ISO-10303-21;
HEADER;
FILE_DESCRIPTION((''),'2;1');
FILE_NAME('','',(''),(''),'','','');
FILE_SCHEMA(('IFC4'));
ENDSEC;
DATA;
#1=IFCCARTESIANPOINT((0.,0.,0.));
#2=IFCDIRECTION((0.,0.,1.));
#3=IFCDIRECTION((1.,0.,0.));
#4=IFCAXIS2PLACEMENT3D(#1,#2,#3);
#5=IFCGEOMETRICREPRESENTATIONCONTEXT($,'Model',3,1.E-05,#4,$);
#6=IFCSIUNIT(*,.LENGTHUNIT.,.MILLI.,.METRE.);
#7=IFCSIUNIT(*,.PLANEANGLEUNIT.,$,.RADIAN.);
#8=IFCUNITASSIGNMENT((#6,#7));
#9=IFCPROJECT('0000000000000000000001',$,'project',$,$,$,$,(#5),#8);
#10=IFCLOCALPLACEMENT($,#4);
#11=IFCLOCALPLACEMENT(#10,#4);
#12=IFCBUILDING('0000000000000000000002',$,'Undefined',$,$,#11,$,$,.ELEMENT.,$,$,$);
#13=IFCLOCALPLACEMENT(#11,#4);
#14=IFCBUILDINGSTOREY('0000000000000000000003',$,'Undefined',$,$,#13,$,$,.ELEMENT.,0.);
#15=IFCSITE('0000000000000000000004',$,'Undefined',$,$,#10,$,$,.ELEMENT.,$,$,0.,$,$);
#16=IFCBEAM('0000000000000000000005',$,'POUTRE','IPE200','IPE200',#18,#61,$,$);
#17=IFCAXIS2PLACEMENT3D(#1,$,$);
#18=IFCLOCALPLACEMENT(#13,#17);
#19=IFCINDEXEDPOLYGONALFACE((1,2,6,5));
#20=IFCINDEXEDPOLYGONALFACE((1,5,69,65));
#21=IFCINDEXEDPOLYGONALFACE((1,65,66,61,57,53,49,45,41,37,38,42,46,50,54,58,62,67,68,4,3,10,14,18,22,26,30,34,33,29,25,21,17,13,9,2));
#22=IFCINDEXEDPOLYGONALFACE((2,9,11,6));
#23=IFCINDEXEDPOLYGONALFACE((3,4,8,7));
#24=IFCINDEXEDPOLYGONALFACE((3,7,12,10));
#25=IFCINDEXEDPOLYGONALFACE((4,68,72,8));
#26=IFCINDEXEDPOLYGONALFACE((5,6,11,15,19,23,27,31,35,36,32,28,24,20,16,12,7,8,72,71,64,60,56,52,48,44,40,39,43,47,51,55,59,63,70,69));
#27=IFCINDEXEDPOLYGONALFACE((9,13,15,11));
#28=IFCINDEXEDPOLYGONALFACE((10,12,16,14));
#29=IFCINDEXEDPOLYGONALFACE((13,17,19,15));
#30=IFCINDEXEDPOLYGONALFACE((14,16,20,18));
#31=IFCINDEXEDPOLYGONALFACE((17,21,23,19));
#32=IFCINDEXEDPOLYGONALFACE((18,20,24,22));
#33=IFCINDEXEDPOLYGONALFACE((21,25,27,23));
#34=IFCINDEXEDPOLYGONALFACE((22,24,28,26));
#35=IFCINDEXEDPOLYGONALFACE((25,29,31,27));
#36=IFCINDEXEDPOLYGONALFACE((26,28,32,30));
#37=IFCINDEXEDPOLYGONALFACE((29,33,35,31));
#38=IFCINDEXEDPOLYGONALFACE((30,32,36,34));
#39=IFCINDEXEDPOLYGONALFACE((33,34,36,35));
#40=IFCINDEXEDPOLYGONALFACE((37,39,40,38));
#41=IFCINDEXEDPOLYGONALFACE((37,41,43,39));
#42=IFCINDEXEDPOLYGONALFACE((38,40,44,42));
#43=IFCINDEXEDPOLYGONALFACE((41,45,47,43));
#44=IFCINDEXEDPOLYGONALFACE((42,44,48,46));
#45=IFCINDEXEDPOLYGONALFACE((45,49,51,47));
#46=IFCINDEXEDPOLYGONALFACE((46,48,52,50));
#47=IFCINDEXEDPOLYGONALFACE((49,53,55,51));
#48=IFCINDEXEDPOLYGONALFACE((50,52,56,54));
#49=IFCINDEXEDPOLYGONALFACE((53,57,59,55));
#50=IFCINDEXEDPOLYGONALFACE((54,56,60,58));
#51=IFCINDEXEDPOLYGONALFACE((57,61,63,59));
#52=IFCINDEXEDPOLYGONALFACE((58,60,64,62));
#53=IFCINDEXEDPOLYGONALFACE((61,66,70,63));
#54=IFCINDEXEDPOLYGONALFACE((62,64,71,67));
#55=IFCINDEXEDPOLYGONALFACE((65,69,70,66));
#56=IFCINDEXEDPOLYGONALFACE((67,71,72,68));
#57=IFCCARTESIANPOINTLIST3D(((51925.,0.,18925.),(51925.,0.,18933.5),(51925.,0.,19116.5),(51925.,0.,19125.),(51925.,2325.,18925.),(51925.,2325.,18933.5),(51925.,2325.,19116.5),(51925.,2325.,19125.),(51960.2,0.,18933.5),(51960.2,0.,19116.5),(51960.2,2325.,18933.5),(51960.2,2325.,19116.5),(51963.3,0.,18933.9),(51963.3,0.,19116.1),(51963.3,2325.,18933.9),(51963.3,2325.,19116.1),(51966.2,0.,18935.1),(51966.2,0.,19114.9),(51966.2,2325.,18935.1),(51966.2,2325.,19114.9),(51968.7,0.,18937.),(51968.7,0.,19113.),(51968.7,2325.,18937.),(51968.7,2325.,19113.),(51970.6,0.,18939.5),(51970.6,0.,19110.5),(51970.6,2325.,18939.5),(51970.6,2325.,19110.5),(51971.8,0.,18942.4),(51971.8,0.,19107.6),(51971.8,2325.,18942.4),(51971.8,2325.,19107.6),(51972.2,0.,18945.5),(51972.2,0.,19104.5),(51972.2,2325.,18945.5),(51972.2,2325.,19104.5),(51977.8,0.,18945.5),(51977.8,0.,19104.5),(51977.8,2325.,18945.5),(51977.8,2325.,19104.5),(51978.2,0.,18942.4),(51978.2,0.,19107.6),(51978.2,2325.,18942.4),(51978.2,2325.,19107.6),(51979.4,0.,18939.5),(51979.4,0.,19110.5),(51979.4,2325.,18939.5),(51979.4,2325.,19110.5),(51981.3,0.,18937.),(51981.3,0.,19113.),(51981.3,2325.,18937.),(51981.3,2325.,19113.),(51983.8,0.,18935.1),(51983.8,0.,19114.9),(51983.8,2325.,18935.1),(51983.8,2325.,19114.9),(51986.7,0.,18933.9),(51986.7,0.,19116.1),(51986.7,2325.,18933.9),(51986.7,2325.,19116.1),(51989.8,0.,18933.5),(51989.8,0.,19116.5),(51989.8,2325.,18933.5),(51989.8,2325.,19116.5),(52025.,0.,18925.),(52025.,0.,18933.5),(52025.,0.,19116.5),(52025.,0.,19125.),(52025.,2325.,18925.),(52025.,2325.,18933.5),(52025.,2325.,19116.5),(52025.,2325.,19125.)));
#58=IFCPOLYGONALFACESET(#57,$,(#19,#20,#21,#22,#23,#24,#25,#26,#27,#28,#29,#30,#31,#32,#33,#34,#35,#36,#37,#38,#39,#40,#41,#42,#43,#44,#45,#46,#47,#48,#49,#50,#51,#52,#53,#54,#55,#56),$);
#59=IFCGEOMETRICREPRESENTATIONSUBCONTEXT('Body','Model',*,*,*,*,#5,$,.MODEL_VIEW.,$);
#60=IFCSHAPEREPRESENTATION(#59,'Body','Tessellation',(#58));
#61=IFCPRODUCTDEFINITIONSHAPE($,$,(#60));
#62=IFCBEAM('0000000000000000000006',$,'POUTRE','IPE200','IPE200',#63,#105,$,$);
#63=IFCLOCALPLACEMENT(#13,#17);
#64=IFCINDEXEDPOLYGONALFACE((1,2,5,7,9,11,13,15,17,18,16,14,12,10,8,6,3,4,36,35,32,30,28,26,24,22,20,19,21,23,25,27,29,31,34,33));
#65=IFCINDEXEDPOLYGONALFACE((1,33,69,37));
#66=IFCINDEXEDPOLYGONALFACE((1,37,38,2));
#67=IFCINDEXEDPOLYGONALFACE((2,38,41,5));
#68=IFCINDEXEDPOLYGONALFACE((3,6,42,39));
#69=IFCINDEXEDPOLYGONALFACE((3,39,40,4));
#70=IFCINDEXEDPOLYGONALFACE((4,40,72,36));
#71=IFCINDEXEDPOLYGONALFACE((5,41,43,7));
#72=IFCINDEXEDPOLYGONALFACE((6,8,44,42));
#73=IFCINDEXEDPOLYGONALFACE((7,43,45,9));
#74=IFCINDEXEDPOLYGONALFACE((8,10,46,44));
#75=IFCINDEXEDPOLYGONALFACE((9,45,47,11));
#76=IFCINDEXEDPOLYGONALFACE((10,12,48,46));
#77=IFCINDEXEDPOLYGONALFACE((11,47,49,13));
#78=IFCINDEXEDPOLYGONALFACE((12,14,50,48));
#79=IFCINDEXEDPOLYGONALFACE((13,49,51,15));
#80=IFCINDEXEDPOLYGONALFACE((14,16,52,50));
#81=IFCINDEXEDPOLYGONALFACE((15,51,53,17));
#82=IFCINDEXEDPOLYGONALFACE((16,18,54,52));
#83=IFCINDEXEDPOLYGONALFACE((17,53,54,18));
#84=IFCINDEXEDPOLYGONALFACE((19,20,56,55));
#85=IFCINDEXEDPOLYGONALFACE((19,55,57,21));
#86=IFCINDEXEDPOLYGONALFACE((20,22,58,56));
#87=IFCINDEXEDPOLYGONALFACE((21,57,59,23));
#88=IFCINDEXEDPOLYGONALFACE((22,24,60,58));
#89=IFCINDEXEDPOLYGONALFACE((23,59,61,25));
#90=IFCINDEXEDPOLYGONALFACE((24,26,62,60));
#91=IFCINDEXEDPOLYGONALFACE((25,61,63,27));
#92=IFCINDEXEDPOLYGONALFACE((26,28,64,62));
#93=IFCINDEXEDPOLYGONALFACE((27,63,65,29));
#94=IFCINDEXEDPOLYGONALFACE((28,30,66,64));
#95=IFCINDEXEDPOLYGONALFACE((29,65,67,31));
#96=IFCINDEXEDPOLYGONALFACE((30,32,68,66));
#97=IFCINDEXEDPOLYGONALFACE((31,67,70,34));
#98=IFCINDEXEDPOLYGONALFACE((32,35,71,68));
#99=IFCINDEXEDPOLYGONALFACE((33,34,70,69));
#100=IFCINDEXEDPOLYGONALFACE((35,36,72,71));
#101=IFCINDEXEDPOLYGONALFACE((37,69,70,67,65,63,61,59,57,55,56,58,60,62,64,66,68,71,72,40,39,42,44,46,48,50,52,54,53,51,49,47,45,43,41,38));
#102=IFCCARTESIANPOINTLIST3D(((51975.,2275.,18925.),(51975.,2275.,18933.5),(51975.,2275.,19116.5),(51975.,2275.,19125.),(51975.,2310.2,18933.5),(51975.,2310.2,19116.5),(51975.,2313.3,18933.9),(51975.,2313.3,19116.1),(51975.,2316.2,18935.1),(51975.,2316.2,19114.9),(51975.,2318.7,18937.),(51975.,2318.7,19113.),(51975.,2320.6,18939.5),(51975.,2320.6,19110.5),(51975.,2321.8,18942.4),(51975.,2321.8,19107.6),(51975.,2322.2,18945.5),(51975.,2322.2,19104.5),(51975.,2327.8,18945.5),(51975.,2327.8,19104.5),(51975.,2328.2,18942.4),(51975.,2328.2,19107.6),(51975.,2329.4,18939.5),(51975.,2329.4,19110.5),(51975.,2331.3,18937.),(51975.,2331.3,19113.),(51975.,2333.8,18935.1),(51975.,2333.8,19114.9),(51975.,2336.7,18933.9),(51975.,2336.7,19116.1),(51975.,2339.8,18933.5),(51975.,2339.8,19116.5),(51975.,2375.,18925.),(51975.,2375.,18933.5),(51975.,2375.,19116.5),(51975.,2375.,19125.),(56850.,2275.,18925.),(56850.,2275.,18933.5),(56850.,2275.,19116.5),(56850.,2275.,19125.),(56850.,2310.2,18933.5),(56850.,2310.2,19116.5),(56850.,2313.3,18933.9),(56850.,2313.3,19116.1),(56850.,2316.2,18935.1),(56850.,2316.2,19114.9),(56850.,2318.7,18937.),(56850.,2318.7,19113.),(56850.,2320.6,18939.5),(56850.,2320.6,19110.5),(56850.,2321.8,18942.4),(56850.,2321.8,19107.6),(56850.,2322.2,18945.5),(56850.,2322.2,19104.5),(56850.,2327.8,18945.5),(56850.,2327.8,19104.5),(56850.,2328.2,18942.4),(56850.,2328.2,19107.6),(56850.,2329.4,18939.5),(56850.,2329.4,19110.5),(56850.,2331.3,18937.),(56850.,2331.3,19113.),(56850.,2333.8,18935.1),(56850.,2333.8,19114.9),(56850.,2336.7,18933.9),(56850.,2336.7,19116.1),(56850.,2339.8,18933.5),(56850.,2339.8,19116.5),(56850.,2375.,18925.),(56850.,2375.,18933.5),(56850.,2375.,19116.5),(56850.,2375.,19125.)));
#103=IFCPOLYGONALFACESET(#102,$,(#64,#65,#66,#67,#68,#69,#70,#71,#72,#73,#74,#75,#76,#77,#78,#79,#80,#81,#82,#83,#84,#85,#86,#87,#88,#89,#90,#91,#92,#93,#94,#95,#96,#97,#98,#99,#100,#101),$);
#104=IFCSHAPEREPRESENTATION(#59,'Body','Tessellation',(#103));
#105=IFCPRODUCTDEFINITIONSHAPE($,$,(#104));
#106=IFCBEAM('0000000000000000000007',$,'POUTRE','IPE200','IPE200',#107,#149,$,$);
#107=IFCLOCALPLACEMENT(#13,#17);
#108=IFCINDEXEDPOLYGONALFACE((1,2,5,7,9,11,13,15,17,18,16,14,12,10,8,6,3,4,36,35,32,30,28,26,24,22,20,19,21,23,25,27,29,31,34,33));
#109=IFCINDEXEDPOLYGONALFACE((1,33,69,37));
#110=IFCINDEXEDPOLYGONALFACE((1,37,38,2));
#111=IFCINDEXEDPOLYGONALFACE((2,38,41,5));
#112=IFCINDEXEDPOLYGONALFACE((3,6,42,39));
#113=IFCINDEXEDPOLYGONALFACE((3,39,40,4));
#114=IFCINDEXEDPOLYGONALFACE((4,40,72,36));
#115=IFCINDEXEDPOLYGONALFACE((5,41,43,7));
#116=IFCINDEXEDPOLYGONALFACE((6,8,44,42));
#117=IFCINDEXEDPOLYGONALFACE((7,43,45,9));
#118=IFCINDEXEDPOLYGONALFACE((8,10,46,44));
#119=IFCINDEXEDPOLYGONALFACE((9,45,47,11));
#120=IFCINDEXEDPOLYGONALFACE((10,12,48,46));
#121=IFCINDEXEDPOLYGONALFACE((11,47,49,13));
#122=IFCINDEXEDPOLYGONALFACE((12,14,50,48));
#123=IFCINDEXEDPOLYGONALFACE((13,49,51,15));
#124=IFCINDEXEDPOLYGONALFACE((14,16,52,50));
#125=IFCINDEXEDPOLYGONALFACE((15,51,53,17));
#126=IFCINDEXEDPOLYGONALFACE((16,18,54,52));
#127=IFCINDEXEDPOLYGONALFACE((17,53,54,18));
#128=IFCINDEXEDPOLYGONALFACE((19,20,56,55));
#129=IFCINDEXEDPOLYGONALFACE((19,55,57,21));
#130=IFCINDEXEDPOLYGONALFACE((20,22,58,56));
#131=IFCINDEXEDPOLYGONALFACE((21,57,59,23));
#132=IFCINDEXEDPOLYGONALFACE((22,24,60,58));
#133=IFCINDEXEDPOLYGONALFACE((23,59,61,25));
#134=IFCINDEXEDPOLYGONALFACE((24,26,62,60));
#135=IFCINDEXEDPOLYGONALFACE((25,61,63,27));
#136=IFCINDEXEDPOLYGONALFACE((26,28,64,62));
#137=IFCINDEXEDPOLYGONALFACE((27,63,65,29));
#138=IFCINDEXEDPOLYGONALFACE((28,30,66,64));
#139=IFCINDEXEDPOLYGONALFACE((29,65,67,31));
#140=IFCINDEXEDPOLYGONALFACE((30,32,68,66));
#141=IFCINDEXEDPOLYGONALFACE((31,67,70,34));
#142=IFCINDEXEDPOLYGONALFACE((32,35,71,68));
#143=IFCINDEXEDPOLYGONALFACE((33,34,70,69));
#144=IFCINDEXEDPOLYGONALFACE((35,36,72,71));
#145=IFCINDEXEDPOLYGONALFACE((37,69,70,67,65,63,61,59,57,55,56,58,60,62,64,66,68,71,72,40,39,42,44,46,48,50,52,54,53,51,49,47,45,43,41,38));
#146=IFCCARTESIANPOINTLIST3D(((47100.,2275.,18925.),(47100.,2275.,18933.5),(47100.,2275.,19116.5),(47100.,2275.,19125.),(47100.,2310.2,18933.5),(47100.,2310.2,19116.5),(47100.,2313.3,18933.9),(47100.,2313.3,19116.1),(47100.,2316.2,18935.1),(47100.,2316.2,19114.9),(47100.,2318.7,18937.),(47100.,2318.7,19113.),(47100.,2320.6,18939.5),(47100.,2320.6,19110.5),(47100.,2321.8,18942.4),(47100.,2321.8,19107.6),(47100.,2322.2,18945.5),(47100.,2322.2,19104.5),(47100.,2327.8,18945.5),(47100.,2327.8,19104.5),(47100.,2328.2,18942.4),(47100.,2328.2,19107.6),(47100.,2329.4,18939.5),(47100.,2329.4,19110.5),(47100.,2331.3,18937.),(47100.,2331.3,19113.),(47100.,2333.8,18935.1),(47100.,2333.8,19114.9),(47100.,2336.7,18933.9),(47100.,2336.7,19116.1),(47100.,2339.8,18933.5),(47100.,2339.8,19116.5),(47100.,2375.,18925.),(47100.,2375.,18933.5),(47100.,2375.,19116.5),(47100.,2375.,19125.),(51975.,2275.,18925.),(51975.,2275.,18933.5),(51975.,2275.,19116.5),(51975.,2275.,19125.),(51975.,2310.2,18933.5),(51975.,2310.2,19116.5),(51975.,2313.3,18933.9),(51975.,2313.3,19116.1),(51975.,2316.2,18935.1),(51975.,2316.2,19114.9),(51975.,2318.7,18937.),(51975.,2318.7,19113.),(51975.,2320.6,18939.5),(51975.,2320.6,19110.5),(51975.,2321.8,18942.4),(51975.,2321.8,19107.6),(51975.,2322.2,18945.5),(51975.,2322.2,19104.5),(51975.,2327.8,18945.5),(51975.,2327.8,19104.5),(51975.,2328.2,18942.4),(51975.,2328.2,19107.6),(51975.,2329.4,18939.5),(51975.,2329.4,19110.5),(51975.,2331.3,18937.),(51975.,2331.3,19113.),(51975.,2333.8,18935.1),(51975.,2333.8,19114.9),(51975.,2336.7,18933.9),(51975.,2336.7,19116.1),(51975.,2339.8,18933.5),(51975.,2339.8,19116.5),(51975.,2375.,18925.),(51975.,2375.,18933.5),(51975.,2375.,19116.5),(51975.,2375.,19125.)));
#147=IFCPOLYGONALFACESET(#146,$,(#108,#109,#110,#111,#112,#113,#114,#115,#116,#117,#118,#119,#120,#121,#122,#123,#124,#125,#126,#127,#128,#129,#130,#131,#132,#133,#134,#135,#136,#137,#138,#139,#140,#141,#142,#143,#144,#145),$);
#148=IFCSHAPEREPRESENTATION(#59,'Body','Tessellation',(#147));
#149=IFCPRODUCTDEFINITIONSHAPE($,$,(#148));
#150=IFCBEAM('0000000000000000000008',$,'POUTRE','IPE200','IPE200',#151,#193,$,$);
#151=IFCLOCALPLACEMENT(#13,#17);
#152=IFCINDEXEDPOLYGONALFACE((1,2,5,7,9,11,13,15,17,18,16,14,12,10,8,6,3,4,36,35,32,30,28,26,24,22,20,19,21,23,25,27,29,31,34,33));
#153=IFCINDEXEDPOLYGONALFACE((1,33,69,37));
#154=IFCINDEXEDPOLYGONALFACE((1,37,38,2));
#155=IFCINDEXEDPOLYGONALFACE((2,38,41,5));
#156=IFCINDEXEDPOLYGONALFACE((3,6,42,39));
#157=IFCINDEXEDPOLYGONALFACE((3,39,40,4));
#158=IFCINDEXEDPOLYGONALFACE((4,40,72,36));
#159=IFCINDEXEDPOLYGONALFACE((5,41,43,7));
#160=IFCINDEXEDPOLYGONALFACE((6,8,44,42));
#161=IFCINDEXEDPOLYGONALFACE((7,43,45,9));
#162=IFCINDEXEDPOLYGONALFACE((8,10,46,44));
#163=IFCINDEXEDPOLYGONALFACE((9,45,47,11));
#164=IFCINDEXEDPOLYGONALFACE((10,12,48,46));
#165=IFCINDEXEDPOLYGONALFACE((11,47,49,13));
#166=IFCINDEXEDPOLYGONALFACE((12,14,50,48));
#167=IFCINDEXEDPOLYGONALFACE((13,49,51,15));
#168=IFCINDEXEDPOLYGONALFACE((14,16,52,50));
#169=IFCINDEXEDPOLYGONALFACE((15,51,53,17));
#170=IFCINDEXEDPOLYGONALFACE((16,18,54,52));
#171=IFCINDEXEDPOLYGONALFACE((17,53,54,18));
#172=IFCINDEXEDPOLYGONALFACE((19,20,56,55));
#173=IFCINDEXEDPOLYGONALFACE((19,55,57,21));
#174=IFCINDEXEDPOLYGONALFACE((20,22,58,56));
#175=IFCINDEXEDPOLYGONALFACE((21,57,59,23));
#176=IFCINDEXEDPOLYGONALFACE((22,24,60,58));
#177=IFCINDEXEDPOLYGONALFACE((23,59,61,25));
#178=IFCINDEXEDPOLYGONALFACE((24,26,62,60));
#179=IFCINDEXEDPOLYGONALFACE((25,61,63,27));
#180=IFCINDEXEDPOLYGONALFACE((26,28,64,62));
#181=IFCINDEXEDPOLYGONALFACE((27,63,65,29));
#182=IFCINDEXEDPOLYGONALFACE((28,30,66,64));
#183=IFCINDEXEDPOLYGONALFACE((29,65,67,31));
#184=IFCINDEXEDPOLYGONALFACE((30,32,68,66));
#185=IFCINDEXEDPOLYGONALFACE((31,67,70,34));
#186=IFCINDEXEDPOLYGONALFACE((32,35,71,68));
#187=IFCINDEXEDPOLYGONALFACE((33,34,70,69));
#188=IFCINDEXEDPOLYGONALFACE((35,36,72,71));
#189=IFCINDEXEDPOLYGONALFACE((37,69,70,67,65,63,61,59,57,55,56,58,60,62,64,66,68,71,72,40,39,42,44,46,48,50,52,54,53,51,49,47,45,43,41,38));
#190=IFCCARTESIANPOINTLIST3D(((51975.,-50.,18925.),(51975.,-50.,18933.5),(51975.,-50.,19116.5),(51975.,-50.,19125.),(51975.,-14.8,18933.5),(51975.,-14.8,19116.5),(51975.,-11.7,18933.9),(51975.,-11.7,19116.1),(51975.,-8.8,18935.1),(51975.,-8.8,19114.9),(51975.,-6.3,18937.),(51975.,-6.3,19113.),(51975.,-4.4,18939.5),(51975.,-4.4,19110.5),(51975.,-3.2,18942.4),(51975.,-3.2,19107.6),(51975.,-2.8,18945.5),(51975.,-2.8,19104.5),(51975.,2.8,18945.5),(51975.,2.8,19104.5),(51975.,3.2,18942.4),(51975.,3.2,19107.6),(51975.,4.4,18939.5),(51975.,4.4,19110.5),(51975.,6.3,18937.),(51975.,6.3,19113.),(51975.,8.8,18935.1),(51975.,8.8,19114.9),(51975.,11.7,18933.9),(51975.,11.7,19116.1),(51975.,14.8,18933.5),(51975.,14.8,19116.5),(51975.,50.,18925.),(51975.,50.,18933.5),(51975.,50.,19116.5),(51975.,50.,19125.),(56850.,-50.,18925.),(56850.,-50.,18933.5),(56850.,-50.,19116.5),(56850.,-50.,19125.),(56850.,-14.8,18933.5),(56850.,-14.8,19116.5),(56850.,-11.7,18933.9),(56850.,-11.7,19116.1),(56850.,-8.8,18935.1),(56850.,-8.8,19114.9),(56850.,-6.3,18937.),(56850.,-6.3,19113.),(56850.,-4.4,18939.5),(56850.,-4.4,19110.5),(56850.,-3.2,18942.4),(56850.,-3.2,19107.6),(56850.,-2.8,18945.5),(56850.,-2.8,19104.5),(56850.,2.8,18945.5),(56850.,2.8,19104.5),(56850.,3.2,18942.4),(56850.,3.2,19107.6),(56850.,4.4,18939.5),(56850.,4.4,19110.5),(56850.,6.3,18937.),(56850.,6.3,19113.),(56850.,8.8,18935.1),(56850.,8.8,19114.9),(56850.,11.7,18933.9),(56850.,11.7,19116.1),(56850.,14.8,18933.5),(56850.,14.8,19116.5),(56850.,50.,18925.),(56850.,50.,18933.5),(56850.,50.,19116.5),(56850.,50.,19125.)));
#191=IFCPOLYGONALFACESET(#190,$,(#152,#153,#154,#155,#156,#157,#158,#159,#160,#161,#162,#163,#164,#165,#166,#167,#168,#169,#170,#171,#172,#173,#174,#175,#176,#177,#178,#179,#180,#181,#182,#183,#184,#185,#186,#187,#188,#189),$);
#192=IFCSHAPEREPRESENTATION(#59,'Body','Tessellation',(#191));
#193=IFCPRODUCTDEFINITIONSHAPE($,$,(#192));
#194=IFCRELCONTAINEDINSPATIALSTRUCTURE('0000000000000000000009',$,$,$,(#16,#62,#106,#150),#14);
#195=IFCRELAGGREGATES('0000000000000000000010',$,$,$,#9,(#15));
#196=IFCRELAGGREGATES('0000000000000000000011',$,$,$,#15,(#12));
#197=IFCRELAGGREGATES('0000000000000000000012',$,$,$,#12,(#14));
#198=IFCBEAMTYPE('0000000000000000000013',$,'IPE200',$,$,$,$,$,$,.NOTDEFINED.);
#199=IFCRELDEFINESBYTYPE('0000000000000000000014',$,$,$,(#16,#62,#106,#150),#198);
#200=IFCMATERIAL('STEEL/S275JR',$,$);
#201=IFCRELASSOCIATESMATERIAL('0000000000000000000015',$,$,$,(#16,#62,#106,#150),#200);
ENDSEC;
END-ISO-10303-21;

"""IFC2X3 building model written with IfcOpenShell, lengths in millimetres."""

from ifc_helpers import new_model, si_unit, frame, origin_with_axes, origin_2d_with_axis, place, context, subcontext, project, spatial, i_section, extrude, material, type_object, element, save


model = new_model("IFC2X3")

# Units and contexts
model_context = context("Model", 3, precision=1e-05, world=origin_with_axes())
body_context = subcontext(model_context, "Body", "Model", "MODEL_VIEW")
ifc_project = project(units=[si_unit("LENGTHUNIT", "METRE", prefix="MILLI"), si_unit("PLANEANGLEUNIT", "RADIAN")], contexts=[model_context])

# Site, building, storey
site_placement = place(None, origin_with_axes())
site = spatial("IfcSite", under=ifc_project, at=site_placement, Name="Undefined", CompositionType="ELEMENT", RefElevation=0.0)
building_placement = place(site_placement, origin_with_axes())
building = spatial("IfcBuilding", under=site, at=building_placement, Name="Undefined", CompositionType="ELEMENT")
storey_placement = place(building_placement, origin_with_axes())
storey = spatial("IfcBuildingStorey", under=building, at=storey_placement, Name="Undefined", CompositionType="ELEMENT", Elevation=0.0)

# Shared definitions
ifc_material_1 = material(Name="STEEL/S275JR")

# Beams
beam_type_1 = type_object("IfcBeamType", Name="IPE200", PredefinedType="NOTDEFINED")
beam_1_placement = place(storey_placement, frame((51975.0, 0.0, 19025.0), z_axis=(0.0, 0.000013, 1.0), x_axis=(0.0, 1.0, -0.000013)))
element("IfcBeam", 1, at=beam_1_placement, inside=storey, type_object=beam_type_1, material=ifc_material_1, Name="POUTRE", Description="IPE200", ObjectType="IPE200", context=body_context, shape_type="SweptSolid", body=[
    extrude(i_section(OverallWidth=100.0, OverallDepth=200.0, WebThickness=5.6, FlangeThickness=8.5, FilletRadius=12.0, at=origin_2d_with_axis()), frame((2325.0, 0.0, 0.0), z_axis=(-1.0, 0.0, 0.0), x_axis=(0.0, -1.0, 0.0)), (0.0, 0.0, 1.0), 2325.0),
])
for number, where, z_axis, x_axis, name in (
    (2, (51975.0, 2325.0, 19025.0), (0.0, 0.0, 1.0), (1.0, 0.0, 0.0), "POUTRE"),
    (3, (47100.0, 2325.0, 19025.0), (0.0, 0.0, 1.0), (1.0, 0.0, 0.0), "POUTRE"),
    (4, (51975.0, 0.0, 19025.0), (0.000006, 0.0, 1.0), (1.0, 0.0, -0.000006), "POUTRE"),
):
    element("IfcBeam", number, at=place(storey_placement, frame(where, z_axis=z_axis, x_axis=x_axis)), inside=storey, type_object=beam_type_1, material=ifc_material_1, Name=name, Description="IPE200", ObjectType="IPE200", context=body_context, shape_type="SweptSolid", body=[
        extrude(i_section(OverallWidth=100.0, OverallDepth=200.0, WebThickness=5.6, FlangeThickness=8.5, FilletRadius=12.0, at=origin_2d_with_axis()), frame((4875.0, 0.0, 0.0), z_axis=(-1.0, 0.0, 0.0), x_axis=(0.0, -1.0, 0.0)), (0.0, 0.0, 1.0), 4875.0),
    ])

save(model, "model.ifc")
